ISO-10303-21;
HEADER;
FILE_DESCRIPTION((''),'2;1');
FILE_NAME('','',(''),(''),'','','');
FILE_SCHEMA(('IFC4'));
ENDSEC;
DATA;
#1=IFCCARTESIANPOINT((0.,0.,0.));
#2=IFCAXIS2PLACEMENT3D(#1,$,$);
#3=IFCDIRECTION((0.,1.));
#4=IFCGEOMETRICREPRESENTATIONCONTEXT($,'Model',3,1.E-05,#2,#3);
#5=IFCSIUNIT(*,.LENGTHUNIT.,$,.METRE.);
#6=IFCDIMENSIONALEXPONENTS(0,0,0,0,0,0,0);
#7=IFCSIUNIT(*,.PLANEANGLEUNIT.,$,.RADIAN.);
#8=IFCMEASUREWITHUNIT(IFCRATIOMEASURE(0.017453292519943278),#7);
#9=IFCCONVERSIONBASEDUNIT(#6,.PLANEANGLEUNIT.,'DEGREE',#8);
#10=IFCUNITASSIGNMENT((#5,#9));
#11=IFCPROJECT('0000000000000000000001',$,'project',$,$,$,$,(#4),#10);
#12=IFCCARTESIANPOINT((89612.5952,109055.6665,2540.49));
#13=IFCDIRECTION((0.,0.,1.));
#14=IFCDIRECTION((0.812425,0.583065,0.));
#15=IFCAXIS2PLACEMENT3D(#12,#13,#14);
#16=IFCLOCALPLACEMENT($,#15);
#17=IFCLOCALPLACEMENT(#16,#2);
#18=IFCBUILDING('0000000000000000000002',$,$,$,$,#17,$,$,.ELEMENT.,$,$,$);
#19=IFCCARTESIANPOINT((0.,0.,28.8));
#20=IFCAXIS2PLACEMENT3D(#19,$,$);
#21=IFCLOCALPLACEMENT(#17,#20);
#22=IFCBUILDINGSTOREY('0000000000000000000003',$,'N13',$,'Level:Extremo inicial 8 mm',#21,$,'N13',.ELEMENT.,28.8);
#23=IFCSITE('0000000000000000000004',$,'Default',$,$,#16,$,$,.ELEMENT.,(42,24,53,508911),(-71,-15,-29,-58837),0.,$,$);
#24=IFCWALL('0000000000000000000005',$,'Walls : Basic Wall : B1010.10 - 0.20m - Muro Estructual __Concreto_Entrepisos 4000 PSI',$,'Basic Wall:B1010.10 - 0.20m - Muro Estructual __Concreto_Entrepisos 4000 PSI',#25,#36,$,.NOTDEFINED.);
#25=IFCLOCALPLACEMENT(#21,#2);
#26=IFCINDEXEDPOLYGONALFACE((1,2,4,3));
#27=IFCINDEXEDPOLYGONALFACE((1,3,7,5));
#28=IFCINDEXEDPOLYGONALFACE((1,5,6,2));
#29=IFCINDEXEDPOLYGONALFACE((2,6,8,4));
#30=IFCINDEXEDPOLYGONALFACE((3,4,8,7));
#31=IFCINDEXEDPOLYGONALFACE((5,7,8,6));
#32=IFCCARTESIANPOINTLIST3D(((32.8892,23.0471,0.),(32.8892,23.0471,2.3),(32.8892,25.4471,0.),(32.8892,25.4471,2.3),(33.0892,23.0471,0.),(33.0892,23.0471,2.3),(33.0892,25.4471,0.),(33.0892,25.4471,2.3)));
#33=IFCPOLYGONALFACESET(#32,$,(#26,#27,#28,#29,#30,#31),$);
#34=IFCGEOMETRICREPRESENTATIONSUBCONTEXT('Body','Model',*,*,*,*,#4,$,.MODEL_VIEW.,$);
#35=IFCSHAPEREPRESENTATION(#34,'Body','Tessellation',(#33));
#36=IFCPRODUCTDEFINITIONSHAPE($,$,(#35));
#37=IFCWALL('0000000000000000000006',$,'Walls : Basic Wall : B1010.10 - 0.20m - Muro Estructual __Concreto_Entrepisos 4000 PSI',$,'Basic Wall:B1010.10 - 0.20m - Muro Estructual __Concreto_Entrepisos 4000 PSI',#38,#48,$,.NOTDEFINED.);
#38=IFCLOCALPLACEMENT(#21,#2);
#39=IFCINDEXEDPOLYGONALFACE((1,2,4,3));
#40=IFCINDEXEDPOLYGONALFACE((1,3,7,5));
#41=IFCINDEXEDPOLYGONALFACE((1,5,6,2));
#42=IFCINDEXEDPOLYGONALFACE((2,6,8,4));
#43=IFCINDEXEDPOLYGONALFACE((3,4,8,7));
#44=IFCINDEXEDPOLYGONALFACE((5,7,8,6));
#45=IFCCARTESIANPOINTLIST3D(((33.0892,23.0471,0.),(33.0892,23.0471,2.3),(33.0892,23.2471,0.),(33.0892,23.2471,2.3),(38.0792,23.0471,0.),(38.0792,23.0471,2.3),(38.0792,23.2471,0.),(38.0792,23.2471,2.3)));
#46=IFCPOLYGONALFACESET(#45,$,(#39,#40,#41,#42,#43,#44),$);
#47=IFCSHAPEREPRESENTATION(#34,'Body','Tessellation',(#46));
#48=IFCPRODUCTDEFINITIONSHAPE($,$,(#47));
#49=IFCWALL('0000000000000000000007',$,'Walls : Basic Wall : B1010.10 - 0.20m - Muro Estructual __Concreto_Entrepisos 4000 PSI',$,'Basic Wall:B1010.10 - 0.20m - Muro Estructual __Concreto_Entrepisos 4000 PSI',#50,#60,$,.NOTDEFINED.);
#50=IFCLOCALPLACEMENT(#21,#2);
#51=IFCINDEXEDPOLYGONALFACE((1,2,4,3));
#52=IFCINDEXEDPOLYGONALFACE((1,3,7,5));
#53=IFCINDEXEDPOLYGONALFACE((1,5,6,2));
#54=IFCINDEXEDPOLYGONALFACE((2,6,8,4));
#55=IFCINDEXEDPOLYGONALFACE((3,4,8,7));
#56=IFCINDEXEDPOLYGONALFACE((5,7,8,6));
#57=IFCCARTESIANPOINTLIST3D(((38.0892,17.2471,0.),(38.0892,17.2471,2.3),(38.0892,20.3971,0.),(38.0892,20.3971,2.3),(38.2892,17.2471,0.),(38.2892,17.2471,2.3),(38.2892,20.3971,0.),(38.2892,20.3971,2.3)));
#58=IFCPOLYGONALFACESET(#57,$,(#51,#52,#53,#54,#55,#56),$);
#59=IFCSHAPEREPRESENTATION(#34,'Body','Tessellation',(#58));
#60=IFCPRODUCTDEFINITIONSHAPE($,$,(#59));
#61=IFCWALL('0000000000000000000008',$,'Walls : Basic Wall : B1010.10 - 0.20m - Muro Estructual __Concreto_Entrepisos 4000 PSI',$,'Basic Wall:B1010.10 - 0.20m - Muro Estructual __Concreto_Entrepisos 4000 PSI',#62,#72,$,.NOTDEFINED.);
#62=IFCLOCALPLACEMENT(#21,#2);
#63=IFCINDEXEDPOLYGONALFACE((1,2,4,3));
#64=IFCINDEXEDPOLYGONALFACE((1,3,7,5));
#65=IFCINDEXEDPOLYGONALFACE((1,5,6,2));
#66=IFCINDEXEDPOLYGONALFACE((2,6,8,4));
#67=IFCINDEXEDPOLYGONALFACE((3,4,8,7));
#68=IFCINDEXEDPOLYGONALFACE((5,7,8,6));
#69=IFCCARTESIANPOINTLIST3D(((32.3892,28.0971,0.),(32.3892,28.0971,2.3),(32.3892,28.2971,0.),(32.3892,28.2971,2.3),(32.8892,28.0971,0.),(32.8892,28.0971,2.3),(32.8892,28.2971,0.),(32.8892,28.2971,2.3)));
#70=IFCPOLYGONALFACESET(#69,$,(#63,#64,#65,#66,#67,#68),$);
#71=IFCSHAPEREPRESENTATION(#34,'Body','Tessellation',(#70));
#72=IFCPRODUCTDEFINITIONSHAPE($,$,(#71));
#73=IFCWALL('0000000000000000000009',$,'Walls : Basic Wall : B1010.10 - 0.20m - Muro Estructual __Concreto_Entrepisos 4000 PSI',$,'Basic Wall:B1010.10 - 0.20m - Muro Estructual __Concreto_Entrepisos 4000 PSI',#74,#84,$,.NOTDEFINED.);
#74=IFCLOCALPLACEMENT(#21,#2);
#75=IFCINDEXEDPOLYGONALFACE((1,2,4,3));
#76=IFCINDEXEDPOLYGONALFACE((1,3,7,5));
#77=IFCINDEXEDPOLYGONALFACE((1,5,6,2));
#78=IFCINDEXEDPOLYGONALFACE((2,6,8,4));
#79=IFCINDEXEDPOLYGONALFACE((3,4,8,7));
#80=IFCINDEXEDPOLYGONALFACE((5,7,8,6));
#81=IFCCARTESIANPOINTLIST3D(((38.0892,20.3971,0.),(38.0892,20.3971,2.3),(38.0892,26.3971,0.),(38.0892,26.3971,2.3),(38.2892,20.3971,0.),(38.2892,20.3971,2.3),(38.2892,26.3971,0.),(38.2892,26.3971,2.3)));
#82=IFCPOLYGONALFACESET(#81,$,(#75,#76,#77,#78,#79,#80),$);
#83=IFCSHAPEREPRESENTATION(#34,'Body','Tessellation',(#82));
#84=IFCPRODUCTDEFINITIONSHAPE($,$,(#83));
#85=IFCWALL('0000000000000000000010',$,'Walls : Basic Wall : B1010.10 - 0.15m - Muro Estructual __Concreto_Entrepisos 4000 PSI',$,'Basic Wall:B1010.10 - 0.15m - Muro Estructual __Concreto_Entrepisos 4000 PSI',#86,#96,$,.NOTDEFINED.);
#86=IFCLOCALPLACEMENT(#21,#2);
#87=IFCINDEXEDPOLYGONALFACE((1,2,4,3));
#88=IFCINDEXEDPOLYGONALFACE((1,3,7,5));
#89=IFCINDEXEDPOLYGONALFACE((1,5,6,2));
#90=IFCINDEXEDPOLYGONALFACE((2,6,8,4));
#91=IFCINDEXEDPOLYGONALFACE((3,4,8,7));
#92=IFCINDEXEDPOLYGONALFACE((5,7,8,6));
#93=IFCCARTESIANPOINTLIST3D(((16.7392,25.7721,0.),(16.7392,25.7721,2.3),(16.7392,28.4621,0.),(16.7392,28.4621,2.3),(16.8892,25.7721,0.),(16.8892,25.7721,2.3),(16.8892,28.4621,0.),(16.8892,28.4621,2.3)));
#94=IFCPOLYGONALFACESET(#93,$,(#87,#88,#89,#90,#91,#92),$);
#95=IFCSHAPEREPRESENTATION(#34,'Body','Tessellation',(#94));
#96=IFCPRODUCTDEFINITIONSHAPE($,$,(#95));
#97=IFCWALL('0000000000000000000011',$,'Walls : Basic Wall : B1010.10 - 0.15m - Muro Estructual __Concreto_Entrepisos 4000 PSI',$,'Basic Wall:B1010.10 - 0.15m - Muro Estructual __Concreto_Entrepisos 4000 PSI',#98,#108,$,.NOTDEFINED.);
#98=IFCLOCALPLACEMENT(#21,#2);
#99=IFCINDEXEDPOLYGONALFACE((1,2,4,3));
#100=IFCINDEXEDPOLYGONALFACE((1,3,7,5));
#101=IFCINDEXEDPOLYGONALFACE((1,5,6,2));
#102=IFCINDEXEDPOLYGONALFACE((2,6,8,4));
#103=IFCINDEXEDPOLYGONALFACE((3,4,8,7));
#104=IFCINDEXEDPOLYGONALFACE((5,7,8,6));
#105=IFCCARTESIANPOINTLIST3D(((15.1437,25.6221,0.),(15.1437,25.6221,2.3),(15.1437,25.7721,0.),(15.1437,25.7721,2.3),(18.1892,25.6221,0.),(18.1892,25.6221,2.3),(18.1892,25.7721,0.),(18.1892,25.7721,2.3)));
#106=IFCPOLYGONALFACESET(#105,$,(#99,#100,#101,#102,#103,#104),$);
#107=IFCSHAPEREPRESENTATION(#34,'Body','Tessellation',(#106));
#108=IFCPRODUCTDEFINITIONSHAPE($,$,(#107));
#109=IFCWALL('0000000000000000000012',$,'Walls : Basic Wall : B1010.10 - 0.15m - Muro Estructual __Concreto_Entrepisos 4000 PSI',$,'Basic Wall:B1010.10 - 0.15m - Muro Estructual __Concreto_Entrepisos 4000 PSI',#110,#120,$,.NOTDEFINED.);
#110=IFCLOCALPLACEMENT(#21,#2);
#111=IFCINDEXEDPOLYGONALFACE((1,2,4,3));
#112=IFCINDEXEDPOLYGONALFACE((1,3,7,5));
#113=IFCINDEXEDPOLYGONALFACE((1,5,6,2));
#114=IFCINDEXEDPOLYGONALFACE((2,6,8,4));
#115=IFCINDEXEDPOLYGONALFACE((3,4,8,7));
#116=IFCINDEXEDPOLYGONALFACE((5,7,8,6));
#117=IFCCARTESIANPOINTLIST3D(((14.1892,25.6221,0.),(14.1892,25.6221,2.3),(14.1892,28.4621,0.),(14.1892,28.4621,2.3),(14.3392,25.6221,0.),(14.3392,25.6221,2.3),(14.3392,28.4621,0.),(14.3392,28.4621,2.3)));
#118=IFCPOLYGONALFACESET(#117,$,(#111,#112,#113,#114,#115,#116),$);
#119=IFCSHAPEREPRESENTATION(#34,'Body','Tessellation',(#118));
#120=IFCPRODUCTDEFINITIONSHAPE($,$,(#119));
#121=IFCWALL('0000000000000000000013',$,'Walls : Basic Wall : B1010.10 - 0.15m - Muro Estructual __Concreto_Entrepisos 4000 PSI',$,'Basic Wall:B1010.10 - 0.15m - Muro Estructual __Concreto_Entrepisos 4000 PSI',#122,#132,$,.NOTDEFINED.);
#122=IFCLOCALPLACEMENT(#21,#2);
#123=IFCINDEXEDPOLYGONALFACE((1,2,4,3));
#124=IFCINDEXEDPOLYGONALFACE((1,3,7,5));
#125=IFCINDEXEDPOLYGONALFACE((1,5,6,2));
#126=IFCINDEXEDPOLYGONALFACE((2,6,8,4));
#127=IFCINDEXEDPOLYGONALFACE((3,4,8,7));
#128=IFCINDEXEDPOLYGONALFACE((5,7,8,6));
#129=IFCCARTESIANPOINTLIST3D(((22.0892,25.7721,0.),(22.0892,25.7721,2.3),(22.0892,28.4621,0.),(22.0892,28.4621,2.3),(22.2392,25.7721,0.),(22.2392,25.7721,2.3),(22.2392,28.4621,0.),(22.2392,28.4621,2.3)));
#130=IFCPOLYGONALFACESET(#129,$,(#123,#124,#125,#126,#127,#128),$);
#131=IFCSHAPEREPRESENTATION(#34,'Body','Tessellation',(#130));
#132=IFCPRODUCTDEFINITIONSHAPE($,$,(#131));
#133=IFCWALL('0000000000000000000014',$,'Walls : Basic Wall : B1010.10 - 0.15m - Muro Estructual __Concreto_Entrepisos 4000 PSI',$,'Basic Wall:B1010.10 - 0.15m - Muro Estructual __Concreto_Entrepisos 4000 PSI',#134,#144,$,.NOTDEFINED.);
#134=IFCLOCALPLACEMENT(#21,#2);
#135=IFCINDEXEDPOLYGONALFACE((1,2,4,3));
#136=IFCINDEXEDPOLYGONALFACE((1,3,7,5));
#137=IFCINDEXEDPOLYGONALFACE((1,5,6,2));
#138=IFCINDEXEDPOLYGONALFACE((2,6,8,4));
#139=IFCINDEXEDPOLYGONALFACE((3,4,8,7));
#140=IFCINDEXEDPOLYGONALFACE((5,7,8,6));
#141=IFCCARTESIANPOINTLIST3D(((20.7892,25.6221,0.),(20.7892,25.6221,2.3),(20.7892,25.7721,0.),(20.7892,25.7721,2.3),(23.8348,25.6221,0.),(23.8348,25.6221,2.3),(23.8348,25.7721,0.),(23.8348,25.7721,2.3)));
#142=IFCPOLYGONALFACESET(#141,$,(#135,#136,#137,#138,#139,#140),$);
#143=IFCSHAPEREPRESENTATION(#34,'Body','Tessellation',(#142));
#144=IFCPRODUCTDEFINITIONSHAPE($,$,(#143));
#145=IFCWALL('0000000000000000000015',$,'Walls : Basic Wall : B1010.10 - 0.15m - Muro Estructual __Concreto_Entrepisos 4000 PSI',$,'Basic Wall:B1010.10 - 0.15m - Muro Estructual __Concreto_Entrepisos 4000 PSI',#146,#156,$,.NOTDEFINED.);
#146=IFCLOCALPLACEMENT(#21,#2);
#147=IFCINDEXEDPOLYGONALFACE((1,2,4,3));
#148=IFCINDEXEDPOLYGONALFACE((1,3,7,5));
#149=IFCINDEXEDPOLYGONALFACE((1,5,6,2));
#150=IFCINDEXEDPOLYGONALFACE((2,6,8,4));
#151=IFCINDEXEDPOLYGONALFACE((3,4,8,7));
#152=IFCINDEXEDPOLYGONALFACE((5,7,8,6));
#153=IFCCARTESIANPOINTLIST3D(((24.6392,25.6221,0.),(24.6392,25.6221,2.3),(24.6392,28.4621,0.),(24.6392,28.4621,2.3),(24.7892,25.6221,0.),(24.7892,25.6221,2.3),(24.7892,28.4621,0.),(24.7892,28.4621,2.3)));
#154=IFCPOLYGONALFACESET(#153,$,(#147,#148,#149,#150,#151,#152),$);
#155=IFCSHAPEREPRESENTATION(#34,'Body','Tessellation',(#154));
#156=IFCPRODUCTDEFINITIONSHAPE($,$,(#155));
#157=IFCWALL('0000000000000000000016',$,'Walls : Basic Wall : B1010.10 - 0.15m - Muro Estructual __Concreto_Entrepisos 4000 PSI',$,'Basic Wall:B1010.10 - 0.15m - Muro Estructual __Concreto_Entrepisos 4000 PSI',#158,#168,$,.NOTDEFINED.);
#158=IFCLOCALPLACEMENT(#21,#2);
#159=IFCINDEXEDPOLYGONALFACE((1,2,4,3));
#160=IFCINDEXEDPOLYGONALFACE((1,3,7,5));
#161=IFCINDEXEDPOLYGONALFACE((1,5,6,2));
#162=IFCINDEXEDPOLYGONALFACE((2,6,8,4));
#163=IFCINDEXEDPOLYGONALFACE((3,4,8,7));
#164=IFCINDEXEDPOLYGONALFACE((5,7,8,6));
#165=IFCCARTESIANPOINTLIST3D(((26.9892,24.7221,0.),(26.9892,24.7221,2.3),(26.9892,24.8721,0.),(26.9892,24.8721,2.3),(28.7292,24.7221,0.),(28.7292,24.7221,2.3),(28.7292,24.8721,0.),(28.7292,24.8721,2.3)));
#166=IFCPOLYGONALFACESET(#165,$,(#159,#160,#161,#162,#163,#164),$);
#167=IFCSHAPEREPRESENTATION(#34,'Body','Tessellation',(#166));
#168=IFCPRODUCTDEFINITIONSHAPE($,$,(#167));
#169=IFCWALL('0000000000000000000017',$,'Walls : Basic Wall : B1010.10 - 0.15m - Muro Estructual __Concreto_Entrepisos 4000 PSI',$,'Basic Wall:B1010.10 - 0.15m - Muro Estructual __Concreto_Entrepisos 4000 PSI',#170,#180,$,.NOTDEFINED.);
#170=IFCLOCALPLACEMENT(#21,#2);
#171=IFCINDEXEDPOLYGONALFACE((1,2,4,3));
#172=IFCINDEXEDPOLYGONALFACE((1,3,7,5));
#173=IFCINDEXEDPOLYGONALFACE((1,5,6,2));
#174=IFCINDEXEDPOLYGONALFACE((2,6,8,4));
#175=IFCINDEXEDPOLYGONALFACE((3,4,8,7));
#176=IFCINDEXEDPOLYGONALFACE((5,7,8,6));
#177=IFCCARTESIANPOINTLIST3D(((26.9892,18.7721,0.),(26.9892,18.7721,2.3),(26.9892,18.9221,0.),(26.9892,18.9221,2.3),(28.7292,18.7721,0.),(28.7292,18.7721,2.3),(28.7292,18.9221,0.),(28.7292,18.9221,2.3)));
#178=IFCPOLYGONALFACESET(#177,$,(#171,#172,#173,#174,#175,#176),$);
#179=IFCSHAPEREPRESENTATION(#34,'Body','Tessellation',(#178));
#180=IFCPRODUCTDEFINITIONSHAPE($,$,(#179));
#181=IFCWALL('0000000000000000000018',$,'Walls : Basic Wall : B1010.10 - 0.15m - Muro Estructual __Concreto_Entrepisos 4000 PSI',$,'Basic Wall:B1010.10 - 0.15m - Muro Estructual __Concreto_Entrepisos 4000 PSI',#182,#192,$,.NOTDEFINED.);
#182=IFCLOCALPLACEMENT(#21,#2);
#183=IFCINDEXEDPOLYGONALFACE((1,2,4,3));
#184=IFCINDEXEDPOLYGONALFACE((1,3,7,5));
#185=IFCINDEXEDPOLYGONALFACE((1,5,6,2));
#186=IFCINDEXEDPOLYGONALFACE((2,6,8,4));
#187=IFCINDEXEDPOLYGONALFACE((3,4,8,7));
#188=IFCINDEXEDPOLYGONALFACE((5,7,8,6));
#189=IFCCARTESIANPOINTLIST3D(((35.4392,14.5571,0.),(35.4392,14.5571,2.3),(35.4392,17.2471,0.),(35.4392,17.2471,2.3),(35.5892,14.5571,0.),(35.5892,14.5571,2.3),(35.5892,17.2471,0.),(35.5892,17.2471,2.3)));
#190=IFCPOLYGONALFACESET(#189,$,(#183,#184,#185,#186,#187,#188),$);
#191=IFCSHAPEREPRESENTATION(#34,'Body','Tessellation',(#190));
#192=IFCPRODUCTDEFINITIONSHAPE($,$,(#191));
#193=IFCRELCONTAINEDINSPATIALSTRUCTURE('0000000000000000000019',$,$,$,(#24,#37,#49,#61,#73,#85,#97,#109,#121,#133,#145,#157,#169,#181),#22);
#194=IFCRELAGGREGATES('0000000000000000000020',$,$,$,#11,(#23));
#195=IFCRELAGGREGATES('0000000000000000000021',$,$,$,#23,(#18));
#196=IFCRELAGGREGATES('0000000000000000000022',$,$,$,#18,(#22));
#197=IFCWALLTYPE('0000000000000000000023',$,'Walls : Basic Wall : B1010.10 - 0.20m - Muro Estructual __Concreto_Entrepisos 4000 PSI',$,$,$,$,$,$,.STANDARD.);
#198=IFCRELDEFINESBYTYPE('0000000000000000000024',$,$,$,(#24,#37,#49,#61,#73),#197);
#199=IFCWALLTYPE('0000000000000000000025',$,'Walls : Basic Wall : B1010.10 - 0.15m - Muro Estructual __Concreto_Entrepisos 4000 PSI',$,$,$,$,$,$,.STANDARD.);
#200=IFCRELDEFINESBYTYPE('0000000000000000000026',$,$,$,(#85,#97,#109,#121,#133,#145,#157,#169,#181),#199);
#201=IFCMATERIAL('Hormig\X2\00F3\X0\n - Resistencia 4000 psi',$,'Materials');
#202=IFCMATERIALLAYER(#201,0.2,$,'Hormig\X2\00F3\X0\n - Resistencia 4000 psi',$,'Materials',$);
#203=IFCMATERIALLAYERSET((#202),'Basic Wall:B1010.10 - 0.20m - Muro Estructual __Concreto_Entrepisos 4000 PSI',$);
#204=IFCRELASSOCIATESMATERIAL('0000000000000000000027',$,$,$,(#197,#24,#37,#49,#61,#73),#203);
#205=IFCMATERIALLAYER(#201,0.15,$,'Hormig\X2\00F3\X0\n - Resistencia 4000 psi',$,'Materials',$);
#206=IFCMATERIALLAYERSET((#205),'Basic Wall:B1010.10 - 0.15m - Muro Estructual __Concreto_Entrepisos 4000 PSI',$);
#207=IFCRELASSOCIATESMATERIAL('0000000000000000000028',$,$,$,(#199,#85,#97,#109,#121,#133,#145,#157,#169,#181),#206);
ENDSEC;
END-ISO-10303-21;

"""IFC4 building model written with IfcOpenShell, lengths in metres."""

from ifc_helpers import new_model, entity, si_unit, converted_unit, direction, frame, frame_2d, origin, place, context, subcontext, project, spatial, rectangle, extrude, material, layer, layer_set, layer_usage, type_object, element, save


model = new_model("IFC4")

# Units and contexts
model_context = context("Model", 3, precision=1e-05, world=origin(), true_north=direction((0.0, 1.0)))
body_context = subcontext(model_context, "Body", "Model", "MODEL_VIEW")
ifc_project = project(units=[si_unit("LENGTHUNIT", "METRE"), converted_unit("PLANEANGLEUNIT", "DEGREE", entity("IfcRatioMeasure", 0.017453292519943278), si_unit("PLANEANGLEUNIT", "RADIAN"), dimensions=[0, 0, 0, 0, 0, 0, 0])], contexts=[model_context])

# Site, building, storey
site_placement = place(None, frame((89612.5952, 109055.6665, 2540.49), z_axis=(0.0, 0.0, 1.0), x_axis=(0.812425, 0.583065, 0.0)))
site = spatial("IfcSite", under=ifc_project, at=site_placement, Name="Default", CompositionType="ELEMENT", RefLatitude=(42, 24, 53, 508911), RefLongitude=(-71, -15, -29, -58837), RefElevation=0.0)
building_placement = place(site_placement, origin())
building = spatial("IfcBuilding", under=site, at=building_placement, CompositionType="ELEMENT")
storey_placement = place(building_placement, frame((0.0, 0.0, 28.8)))
storey = spatial("IfcBuildingStorey", under=building, at=storey_placement, Name="N13", ObjectType="Level:Extremo inicial 8 mm", LongName="N13", CompositionType="ELEMENT", Elevation=28.8)

# Walls
ifc_material = material(Name="Hormigón - Resistencia 4000 psi", Category="Materials")
ifc_layer_1 = layer(ifc_material, 0.2, Name="Hormigón - Resistencia 4000 psi", Category="Materials")
ifc_layer_set_1 = layer_set([ifc_layer_1], Name="Basic Wall:B1010.10 - 0.20m - Muro Estructual __Concreto_Entrepisos 4000 PSI")
wall_type_1 = type_object("IfcWallType", Name="Walls : Basic Wall : B1010.10 - 0.20m - Muro Estructual __Concreto_Entrepisos 4000 PSI", PredefinedType="STANDARD", material=ifc_layer_set_1)
ifc_layer_usage_1 = layer_usage(ifc_layer_set_1, "AXIS2", "POSITIVE", -0.1)
wall_1_placement = place(storey_placement, frame((32.9892, 25.4471, 0.0), z_axis=(0.0, 0.0, 1.0), x_axis=(0.0, -1.0, 0.0)))
element("IfcWall", 1, at=wall_1_placement, inside=storey, type_object=wall_type_1, material=ifc_layer_usage_1, Name="Walls : Basic Wall : B1010.10 - 0.20m - Muro Estructual __Concreto_Entrepisos 4000 PSI", ObjectType="Basic Wall:B1010.10 - 0.20m - Muro Estructual __Concreto_Entrepisos 4000 PSI", PredefinedType="NOTDEFINED", context=body_context, shape_type="SweptSolid", body=[
    extrude(rectangle(XDim=2.4, YDim=0.2, at=frame_2d((1.2, 0.0), x_axis=(-1.0, 0.0))), origin(), (0.0, 0.0, 1.0), 2.3),
])
ifc_layer_usage_2 = layer_usage(ifc_layer_set_1, "AXIS2", "POSITIVE", -0.1)
wall_2_placement = place(storey_placement, frame((33.0892, 23.1471, 0.0)))
element("IfcWall", 2, at=wall_2_placement, inside=storey, type_object=wall_type_1, material=ifc_layer_usage_2, Name="Walls : Basic Wall : B1010.10 - 0.20m - Muro Estructual __Concreto_Entrepisos 4000 PSI", ObjectType="Basic Wall:B1010.10 - 0.20m - Muro Estructual __Concreto_Entrepisos 4000 PSI", PredefinedType="NOTDEFINED", context=body_context, shape_type="SweptSolid", body=[
    extrude(rectangle(XDim=4.99, YDim=0.2, at=frame_2d((2.495, 0.0), x_axis=(-1.0, 0.0))), origin(), (0.0, 0.0, 1.0), 2.3),
])
ifc_layer_usage_3 = layer_usage(ifc_layer_set_1, "AXIS2", "POSITIVE", -0.1)
wall_3_placement = place(storey_placement, frame((38.1892, 17.2471, 0.0), z_axis=(0.0, 0.0, 1.0), x_axis=(0.0, 1.0, 0.0)))
element("IfcWall", 3, at=wall_3_placement, inside=storey, type_object=wall_type_1, material=ifc_layer_usage_3, Name="Walls : Basic Wall : B1010.10 - 0.20m - Muro Estructual __Concreto_Entrepisos 4000 PSI", ObjectType="Basic Wall:B1010.10 - 0.20m - Muro Estructual __Concreto_Entrepisos 4000 PSI", PredefinedType="NOTDEFINED", context=body_context, shape_type="SweptSolid", body=[
    extrude(rectangle(XDim=3.15, YDim=0.2, at=frame_2d((1.575, 0.0), x_axis=(-1.0, 0.0))), origin(), (0.0, 0.0, 1.0), 2.3),
])
ifc_layer_usage_4 = layer_usage(ifc_layer_set_1, "AXIS2", "POSITIVE", -0.1)
wall_4_placement = place(storey_placement, frame((32.3892, 28.1971, 0.0)))
element("IfcWall", 4, at=wall_4_placement, inside=storey, type_object=wall_type_1, material=ifc_layer_usage_4, Name="Walls : Basic Wall : B1010.10 - 0.20m - Muro Estructual __Concreto_Entrepisos 4000 PSI", ObjectType="Basic Wall:B1010.10 - 0.20m - Muro Estructual __Concreto_Entrepisos 4000 PSI", PredefinedType="NOTDEFINED", context=body_context, shape_type="SweptSolid", body=[
    extrude(rectangle(XDim=0.5, YDim=0.2, at=frame_2d((0.25, 0.0), x_axis=(-1.0, 0.0))), origin(), (0.0, 0.0, 1.0), 2.3),
])
ifc_layer_usage_5 = layer_usage(ifc_layer_set_1, "AXIS2", "POSITIVE", -0.1)
wall_5_placement = place(storey_placement, frame((38.1892, 20.3971, 0.0), z_axis=(0.0, 0.0, 1.0), x_axis=(0.0, 1.0, 0.0)))
element("IfcWall", 5, at=wall_5_placement, inside=storey, type_object=wall_type_1, material=ifc_layer_usage_5, Name="Walls : Basic Wall : B1010.10 - 0.20m - Muro Estructual __Concreto_Entrepisos 4000 PSI", ObjectType="Basic Wall:B1010.10 - 0.20m - Muro Estructual __Concreto_Entrepisos 4000 PSI", PredefinedType="NOTDEFINED", context=body_context, shape_type="SweptSolid", body=[
    extrude(rectangle(XDim=6.0, YDim=0.2, at=frame_2d((3.0, 0.0), x_axis=(-1.0, 0.0))), origin(), (0.0, 0.0, 1.0), 2.3),
])
ifc_layer_2 = layer(ifc_material, 0.15, Name="Hormigón - Resistencia 4000 psi", Category="Materials")
ifc_layer_set_2 = layer_set([ifc_layer_2], Name="Basic Wall:B1010.10 - 0.15m - Muro Estructual __Concreto_Entrepisos 4000 PSI")
ifc_layer_usage_6 = layer_usage(ifc_layer_set_2, "AXIS2", "POSITIVE", -0.075)
wall_type_2 = type_object("IfcWallType", Name="Walls : Basic Wall : B1010.10 - 0.15m - Muro Estructual __Concreto_Entrepisos 4000 PSI", PredefinedType="STANDARD", material=ifc_layer_set_2)
wall_6_placement = place(storey_placement, frame((16.8142, 28.4621, 0.0), z_axis=(0.0, 0.0, 1.0), x_axis=(0.0, -1.0, 0.0)))
element("IfcWall", 6, at=wall_6_placement, inside=storey, type_object=wall_type_2, material=ifc_layer_usage_6, Name="Walls : Basic Wall : B1010.10 - 0.15m - Muro Estructual __Concreto_Entrepisos 4000 PSI", ObjectType="Basic Wall:B1010.10 - 0.15m - Muro Estructual __Concreto_Entrepisos 4000 PSI", PredefinedType="NOTDEFINED", context=body_context, shape_type="SweptSolid", body=[
    extrude(rectangle(XDim=2.69, YDim=0.15, at=frame_2d((1.345, 0.0), x_axis=(-1.0, 0.0))), origin(), (0.0, 0.0, 1.0), 2.3),
])
ifc_layer_usage_7 = layer_usage(ifc_layer_set_2, "AXIS2", "POSITIVE", -0.075)
wall_7_placement = place(storey_placement, frame((18.1892, 25.6971, 0.0), z_axis=(0.0, 0.0, 1.0), x_axis=(-1.0, 0.0, 0.0)))
element("IfcWall", 7, at=wall_7_placement, inside=storey, type_object=wall_type_2, material=ifc_layer_usage_7, Name="Walls : Basic Wall : B1010.10 - 0.15m - Muro Estructual __Concreto_Entrepisos 4000 PSI", ObjectType="Basic Wall:B1010.10 - 0.15m - Muro Estructual __Concreto_Entrepisos 4000 PSI", PredefinedType="NOTDEFINED", context=body_context, shape_type="SweptSolid", body=[
    extrude(rectangle(XDim=3.0455, YDim=0.15, at=frame_2d((1.5228, 0.0), x_axis=(-1.0, 0.0))), origin(), (0.0, 0.0, 1.0), 2.3),
])
ifc_layer_usage_8 = layer_usage(ifc_layer_set_2, "AXIS2", "POSITIVE", -0.075)
wall_8_placement = place(storey_placement, frame((14.2642, 28.4621, 0.0), z_axis=(0.0, 0.0, 1.0), x_axis=(0.0, -1.0, 0.0)))
element("IfcWall", 8, at=wall_8_placement, inside=storey, type_object=wall_type_2, material=ifc_layer_usage_8, Name="Walls : Basic Wall : B1010.10 - 0.15m - Muro Estructual __Concreto_Entrepisos 4000 PSI", ObjectType="Basic Wall:B1010.10 - 0.15m - Muro Estructual __Concreto_Entrepisos 4000 PSI", PredefinedType="NOTDEFINED", context=body_context, shape_type="SweptSolid", body=[
    extrude(rectangle(XDim=2.84, YDim=0.15, at=frame_2d((1.42, 0.0), x_axis=(-1.0, 0.0))), origin(), (0.0, 0.0, 1.0), 2.3),
])
ifc_layer_usage_9 = layer_usage(ifc_layer_set_2, "AXIS2", "NEGATIVE", 0.075)
wall_9_placement = place(storey_placement, frame((22.1642, 28.4621, 0.0), z_axis=(0.0, 0.0, 1.0), x_axis=(0.0, -1.0, 0.0)))
element("IfcWall", 9, at=wall_9_placement, inside=storey, type_object=wall_type_2, material=ifc_layer_usage_9, Name="Walls : Basic Wall : B1010.10 - 0.15m - Muro Estructual __Concreto_Entrepisos 4000 PSI", ObjectType="Basic Wall:B1010.10 - 0.15m - Muro Estructual __Concreto_Entrepisos 4000 PSI", PredefinedType="NOTDEFINED", context=body_context, shape_type="SweptSolid", body=[
    extrude(rectangle(XDim=2.69, YDim=0.15, at=frame_2d((1.345, 0.0), x_axis=(-1.0, 0.0))), origin(), (0.0, 0.0, 1.0), 2.3),
])
ifc_layer_usage_10 = layer_usage(ifc_layer_set_2, "AXIS2", "NEGATIVE", 0.075)
wall_10_placement = place(storey_placement, frame((20.7892, 25.6971, 0.0)))
element("IfcWall", 10, at=wall_10_placement, inside=storey, type_object=wall_type_2, material=ifc_layer_usage_10, Name="Walls : Basic Wall : B1010.10 - 0.15m - Muro Estructual __Concreto_Entrepisos 4000 PSI", ObjectType="Basic Wall:B1010.10 - 0.15m - Muro Estructual __Concreto_Entrepisos 4000 PSI", PredefinedType="NOTDEFINED", context=body_context, shape_type="SweptSolid", body=[
    extrude(rectangle(XDim=3.0455, YDim=0.15, at=frame_2d((1.5228, 0.0), x_axis=(-1.0, 0.0))), origin(), (0.0, 0.0, 1.0), 2.3),
])
ifc_layer_usage_11 = layer_usage(ifc_layer_set_2, "AXIS2", "NEGATIVE", 0.075)
wall_11_placement = place(storey_placement, frame((24.7142, 28.4621, 0.0), z_axis=(0.0, 0.0, 1.0), x_axis=(0.0, -1.0, 0.0)))
element("IfcWall", 11, at=wall_11_placement, inside=storey, type_object=wall_type_2, material=ifc_layer_usage_11, Name="Walls : Basic Wall : B1010.10 - 0.15m - Muro Estructual __Concreto_Entrepisos 4000 PSI", ObjectType="Basic Wall:B1010.10 - 0.15m - Muro Estructual __Concreto_Entrepisos 4000 PSI", PredefinedType="NOTDEFINED", context=body_context, shape_type="SweptSolid", body=[
    extrude(rectangle(XDim=2.84, YDim=0.15, at=frame_2d((1.42, 0.0), x_axis=(-1.0, 0.0))), origin(), (0.0, 0.0, 1.0), 2.3),
])
ifc_layer_usage_12 = layer_usage(ifc_layer_set_2, "AXIS2", "NEGATIVE", 0.075)
wall_12_placement = place(storey_placement, frame((26.9892, 24.7971, 0.0)))
element("IfcWall", 12, at=wall_12_placement, inside=storey, type_object=wall_type_2, material=ifc_layer_usage_12, Name="Walls : Basic Wall : B1010.10 - 0.15m - Muro Estructual __Concreto_Entrepisos 4000 PSI", ObjectType="Basic Wall:B1010.10 - 0.15m - Muro Estructual __Concreto_Entrepisos 4000 PSI", PredefinedType="NOTDEFINED", context=body_context, shape_type="SweptSolid", body=[
    extrude(rectangle(XDim=1.74, YDim=0.15, at=frame_2d((0.87, 0.0), x_axis=(-1.0, 0.0))), origin(), (0.0, 0.0, 1.0), 2.3),
])
ifc_layer_usage_13 = layer_usage(ifc_layer_set_2, "AXIS2", "POSITIVE", -0.075)
wall_13_placement = place(storey_placement, frame((26.9892, 18.8471, 0.0)))
element("IfcWall", 13, at=wall_13_placement, inside=storey, type_object=wall_type_2, material=ifc_layer_usage_13, Name="Walls : Basic Wall : B1010.10 - 0.15m - Muro Estructual __Concreto_Entrepisos 4000 PSI", ObjectType="Basic Wall:B1010.10 - 0.15m - Muro Estructual __Concreto_Entrepisos 4000 PSI", PredefinedType="NOTDEFINED", context=body_context, shape_type="SweptSolid", body=[
    extrude(rectangle(XDim=1.74, YDim=0.15, at=frame_2d((0.87, 0.0), x_axis=(-1.0, 0.0))), origin(), (0.0, 0.0, 1.0), 2.3),
])
ifc_layer_usage_14 = layer_usage(ifc_layer_set_2, "AXIS2", "NEGATIVE", 0.075)
wall_14_placement = place(storey_placement, frame((35.5142, 14.5571, 0.0), z_axis=(0.0, 0.0, 1.0), x_axis=(0.0, 1.0, 0.0)))
element("IfcWall", 14, at=wall_14_placement, inside=storey, type_object=wall_type_2, material=ifc_layer_usage_14, Name="Walls : Basic Wall : B1010.10 - 0.15m - Muro Estructual __Concreto_Entrepisos 4000 PSI", ObjectType="Basic Wall:B1010.10 - 0.15m - Muro Estructual __Concreto_Entrepisos 4000 PSI", PredefinedType="NOTDEFINED", context=body_context, shape_type="SweptSolid", body=[
    extrude(rectangle(XDim=2.69, YDim=0.15, at=frame_2d((1.345, 0.0), x_axis=(-1.0, 0.0))), origin(), (0.0, 0.0, 1.0), 2.3),
])

save(model, "model.ifc")
